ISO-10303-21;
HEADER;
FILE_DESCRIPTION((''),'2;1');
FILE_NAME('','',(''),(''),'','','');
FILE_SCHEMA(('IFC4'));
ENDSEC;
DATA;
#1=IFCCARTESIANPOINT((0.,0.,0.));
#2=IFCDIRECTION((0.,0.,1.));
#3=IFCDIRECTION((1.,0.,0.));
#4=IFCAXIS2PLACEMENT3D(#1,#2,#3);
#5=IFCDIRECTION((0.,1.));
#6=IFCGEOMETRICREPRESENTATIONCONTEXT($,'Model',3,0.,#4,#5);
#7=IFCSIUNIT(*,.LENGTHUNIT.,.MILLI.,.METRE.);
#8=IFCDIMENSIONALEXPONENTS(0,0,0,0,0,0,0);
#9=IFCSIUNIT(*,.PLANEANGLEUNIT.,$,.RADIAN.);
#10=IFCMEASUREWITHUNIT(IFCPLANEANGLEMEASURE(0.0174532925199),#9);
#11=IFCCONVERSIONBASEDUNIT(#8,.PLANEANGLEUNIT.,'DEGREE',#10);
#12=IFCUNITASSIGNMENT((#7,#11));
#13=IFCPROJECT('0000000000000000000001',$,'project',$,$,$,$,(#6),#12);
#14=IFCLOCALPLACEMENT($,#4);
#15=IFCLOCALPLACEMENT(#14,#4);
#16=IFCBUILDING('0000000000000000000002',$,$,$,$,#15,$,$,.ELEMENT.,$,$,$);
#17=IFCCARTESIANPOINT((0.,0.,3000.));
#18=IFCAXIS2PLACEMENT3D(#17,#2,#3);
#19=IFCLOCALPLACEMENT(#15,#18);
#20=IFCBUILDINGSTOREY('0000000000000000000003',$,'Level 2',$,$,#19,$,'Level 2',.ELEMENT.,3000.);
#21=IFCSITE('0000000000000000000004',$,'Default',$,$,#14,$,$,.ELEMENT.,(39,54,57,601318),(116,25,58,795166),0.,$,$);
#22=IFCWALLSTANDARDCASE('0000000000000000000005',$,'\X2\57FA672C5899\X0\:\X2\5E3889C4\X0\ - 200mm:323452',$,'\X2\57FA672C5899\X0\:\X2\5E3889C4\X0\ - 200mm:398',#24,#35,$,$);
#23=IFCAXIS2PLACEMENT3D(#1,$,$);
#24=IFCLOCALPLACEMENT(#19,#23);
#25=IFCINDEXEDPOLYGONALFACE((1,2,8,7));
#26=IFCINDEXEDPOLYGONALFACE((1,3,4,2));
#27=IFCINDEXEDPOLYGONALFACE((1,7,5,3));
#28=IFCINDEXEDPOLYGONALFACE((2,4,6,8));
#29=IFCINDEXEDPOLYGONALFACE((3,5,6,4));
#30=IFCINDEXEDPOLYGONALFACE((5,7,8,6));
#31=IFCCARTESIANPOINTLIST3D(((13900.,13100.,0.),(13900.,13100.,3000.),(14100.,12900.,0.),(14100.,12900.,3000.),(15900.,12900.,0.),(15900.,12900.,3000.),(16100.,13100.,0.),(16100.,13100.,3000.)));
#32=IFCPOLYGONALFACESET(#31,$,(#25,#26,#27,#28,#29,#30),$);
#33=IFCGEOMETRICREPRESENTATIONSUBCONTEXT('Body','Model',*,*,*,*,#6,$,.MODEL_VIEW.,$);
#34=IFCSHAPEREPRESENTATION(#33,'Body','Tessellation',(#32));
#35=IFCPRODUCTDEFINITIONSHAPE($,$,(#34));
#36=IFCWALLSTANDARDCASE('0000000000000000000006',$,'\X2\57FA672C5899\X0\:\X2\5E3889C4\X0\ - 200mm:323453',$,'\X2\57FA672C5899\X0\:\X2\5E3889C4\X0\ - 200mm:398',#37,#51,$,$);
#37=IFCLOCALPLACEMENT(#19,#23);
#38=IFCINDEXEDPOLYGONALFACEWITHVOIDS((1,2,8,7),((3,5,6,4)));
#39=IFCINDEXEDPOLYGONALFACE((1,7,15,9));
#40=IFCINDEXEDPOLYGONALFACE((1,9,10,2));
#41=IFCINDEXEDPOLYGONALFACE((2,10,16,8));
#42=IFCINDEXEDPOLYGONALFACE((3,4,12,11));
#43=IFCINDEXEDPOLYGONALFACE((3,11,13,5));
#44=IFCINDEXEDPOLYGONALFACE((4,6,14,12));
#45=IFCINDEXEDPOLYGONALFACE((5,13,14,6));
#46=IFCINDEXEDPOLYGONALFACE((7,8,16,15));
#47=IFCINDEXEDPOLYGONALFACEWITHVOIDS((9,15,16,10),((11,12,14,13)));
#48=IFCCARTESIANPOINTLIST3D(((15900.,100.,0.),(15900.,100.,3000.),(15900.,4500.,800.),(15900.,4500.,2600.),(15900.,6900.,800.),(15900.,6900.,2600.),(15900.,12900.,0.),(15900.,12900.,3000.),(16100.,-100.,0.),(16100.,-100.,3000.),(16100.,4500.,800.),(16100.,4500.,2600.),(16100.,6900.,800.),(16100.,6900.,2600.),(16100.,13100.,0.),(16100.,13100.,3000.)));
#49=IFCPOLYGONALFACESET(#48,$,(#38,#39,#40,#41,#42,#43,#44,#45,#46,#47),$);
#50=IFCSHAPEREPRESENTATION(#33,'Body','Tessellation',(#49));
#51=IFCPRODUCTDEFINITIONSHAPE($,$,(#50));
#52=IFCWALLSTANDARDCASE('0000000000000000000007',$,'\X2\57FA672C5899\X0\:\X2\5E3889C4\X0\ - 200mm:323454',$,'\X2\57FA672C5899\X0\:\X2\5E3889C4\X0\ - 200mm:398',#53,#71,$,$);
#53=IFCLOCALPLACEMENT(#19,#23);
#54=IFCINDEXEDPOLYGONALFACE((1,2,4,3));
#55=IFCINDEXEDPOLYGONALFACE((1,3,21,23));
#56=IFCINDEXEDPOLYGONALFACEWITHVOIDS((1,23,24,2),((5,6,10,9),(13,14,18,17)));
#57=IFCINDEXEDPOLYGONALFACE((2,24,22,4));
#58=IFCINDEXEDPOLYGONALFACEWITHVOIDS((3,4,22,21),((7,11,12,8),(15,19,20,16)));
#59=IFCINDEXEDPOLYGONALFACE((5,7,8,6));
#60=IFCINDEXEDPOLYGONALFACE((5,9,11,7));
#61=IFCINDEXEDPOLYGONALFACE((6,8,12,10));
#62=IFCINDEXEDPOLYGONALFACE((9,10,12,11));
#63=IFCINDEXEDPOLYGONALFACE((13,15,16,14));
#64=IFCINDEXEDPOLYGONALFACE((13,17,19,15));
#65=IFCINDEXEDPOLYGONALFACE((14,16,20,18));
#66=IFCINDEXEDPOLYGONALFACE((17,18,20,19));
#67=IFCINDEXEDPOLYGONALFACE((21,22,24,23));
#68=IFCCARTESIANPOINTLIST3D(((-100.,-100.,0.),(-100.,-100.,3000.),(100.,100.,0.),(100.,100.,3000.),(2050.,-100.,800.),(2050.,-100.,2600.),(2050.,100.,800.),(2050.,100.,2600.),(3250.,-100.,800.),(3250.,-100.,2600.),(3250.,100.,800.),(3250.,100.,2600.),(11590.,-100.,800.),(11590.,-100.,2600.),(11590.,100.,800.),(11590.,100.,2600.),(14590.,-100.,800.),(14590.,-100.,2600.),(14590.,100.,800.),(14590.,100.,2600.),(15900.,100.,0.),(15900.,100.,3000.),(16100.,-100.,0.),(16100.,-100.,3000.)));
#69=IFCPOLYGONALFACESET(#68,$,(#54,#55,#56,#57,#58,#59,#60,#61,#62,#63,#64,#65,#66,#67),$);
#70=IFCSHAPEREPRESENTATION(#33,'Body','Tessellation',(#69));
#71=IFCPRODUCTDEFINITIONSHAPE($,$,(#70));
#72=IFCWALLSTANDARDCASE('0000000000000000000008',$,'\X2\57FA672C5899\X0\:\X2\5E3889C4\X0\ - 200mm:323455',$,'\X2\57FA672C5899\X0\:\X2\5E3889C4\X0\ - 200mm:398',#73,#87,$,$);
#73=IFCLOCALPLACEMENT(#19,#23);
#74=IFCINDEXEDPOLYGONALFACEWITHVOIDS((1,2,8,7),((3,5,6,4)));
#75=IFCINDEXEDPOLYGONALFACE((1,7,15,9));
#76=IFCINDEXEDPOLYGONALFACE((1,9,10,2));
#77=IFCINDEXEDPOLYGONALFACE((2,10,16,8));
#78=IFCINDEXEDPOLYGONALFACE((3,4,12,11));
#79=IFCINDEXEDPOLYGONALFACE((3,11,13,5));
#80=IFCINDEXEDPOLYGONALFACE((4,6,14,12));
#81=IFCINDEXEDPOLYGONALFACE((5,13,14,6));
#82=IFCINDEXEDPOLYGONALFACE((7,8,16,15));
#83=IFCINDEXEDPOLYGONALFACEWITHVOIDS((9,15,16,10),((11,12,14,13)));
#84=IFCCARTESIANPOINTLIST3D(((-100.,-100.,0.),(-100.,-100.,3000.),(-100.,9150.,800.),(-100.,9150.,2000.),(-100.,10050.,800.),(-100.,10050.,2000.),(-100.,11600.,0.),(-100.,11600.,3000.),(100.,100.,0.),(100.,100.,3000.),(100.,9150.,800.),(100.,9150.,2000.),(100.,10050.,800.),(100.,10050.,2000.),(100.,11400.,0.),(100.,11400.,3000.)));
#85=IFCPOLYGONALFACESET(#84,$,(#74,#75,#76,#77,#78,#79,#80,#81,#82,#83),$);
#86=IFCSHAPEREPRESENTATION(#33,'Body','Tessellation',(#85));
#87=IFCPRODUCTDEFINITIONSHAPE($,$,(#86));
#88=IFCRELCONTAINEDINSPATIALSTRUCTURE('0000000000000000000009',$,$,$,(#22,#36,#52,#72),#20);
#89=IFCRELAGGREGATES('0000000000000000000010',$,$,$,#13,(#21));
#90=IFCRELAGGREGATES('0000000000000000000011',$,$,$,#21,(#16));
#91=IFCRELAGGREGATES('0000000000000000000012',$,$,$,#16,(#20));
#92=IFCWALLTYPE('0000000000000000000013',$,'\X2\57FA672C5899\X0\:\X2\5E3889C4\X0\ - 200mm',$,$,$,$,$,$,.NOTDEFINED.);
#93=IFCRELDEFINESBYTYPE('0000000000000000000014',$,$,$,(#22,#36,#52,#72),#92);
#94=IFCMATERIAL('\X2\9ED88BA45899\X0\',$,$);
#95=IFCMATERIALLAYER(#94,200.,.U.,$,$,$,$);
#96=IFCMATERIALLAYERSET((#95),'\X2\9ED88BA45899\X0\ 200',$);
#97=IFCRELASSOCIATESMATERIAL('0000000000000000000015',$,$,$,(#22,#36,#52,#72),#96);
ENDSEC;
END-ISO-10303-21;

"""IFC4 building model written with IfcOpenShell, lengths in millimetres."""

from ifc_helpers import new_model, entity, si_unit, converted_unit, direction, frame, origin_with_axes, place, context, subcontext, project, spatial, polyline, outline, extrude, material, layer, layer_set, layer_usage, type_object, element, save


model = new_model("IFC4")

# Units and contexts
model_context = context("Model", 3, precision=0.0, world=origin_with_axes(), true_north=direction((0.0, 1.0)))
body_context = subcontext(model_context, "Body", "Model", "MODEL_VIEW")
ifc_project = project(units=[si_unit("LENGTHUNIT", "METRE", prefix="MILLI"), converted_unit("PLANEANGLEUNIT", "DEGREE", entity("IfcPlaneAngleMeasure", 0.0174532925199), si_unit("PLANEANGLEUNIT", "RADIAN"), dimensions=[0, 0, 0, 0, 0, 0, 0])], contexts=[model_context])

# Site, building, storey
site_placement = place(None, origin_with_axes())
site = spatial("IfcSite", under=ifc_project, at=site_placement, Name="Default", CompositionType="ELEMENT", RefLatitude=(39, 54, 57, 601318), RefLongitude=(116, 25, 58, 795166), RefElevation=0.0)
building_placement = place(site_placement, origin_with_axes())
building = spatial("IfcBuilding", under=site, at=building_placement, CompositionType="ELEMENT")
storey_placement = place(building_placement, frame((0.0, 0.0, 3000.0), z_axis=(0.0, 0.0, 1.0), x_axis=(1.0, 0.0, 0.0)))
storey = spatial("IfcBuildingStorey", under=building, at=storey_placement, Name="Level 2", LongName="Level 2", CompositionType="ELEMENT", Elevation=3000.0)

# Shared definitions
ifc_material_1 = material(Name="默认墙")
ifc_layer_1 = layer(ifc_material_1, 200.0, ventilated="UNKNOWN")
ifc_layer_set_1 = layer_set([ifc_layer_1], Name="默认墙 200")
wall_type = type_object("IfcWallType", Name="基本墙:常规 - 200mm", PredefinedType="NOTDEFINED")

# Wall
ifc_layer_usage_1 = layer_usage(ifc_layer_set_1, "AXIS2", "POSITIVE", -100.0)
wall_1_placement = place(storey_placement, frame((14000.0, 13000.0, 0.0), z_axis=(0.0, 0.0, 1.0), x_axis=(1.0, 0.0, 0.0)))
element("IfcWallStandardCase", 1, at=wall_1_placement, inside=storey, type_object=wall_type, material=ifc_layer_usage_1, Name="基本墙:常规 - 200mm:323452", ObjectType="基本墙:常规 - 200mm:398", context=body_context, shape_type="SweptSolid", body=[
    extrude(outline(polyline([(100.0, -100.0), (1900.0, -100.0), (2100.0, 100.0), (-100.0, 100.0), (100.0, -100.0)])), origin_with_axes(), (0.0, 0.0, 1.0), 3000.0),
])

# Wall, opening
ifc_layer_usage_2 = layer_usage(ifc_layer_set_1, "AXIS2", "POSITIVE", -100.0)
wall_2_placement = place(storey_placement, frame((16000.0, 13000.0, 0.0), z_axis=(0.0, 0.0, 1.0), x_axis=(0.0, -1.0, 0.0)))
wall_2 = element("IfcWallStandardCase", 2, at=wall_2_placement, inside=storey, type_object=wall_type, material=ifc_layer_usage_2, Name="基本墙:常规 - 200mm:323453", ObjectType="基本墙:常规 - 200mm:398", context=body_context, shape_type="SweptSolid", body=[
    extrude(outline(polyline([(100.0, -100.0), (12900.0, -100.0), (13100.0, 100.0), (-100.0, 100.0), (100.0, -100.0)])), origin_with_axes(), (0.0, 0.0, 1.0), 3000.0),
])
opening_1_placement = place(wall_2_placement, frame((7300.0, 0.0, 800.0), z_axis=(0.0, 0.0, 1.0), x_axis=(1.0, 0.0, 0.0)))
element("IfcOpeningElement", 3, at=opening_1_placement, cuts=wall_2, context=body_context, shape_type="SweptSolid", body=[
    extrude(outline(polyline([(-1200.0, 0.0), (-1200.0, -1800.0), (1200.0, -1800.0), (1200.0, 0.0), (-1200.0, 0.0)])), frame((0.0, -100.0, 0.0), z_axis=(0.0, 1.0, 0.0), x_axis=(1.0, 0.0, 0.0)), (0.0, 0.0, 1.0), 200.0),
])

# Wall, openings
ifc_layer_usage_3 = layer_usage(ifc_layer_set_1, "AXIS2", "POSITIVE", -100.0)
wall_3_placement = place(storey_placement, frame((16000.0, 0.0, 0.0), z_axis=(0.0, 0.0, 1.0), x_axis=(-1.0, 0.0, 0.0)))
wall_3 = element("IfcWallStandardCase", 4, at=wall_3_placement, inside=storey, type_object=wall_type, material=ifc_layer_usage_3, Name="基本墙:常规 - 200mm:323454", ObjectType="基本墙:常规 - 200mm:398", context=body_context, shape_type="SweptSolid", body=[
    extrude(outline(polyline([(100.0, -100.0), (15900.0, -100.0), (16100.0, 100.0), (-100.0, 100.0), (100.0, -100.0)])), origin_with_axes(), (0.0, 0.0, 1.0), 3000.0),
])
opening_2_placement = place(wall_3_placement, frame((13350.0, 0.0, 800.0), z_axis=(0.0, 0.0, 1.0), x_axis=(1.0, 0.0, 0.0)))
element("IfcOpeningElement", 5, at=opening_2_placement, cuts=wall_3, context=body_context, shape_type="SweptSolid", body=[
    extrude(outline(polyline([(-600.0, 0.0), (-600.0, -1800.0), (600.0, -1800.0), (600.0, 0.0), (-600.0, 0.0)])), frame((0.0, -100.0, 0.0), z_axis=(0.0, 1.0, 0.0), x_axis=(1.0, 0.0, 0.0)), (0.0, 0.0, 1.0), 200.0),
])
opening_3_placement = place(wall_3_placement, frame((2910.0, 0.0, 800.0), z_axis=(0.0, 0.0, 1.0), x_axis=(1.0, 0.0, 0.0)))
element("IfcOpeningElement", 6, at=opening_3_placement, cuts=wall_3, context=body_context, shape_type="SweptSolid", body=[
    extrude(outline(polyline([(-1500.0, 0.0), (-1500.0, -1800.0), (1500.0, -1800.0), (1500.0, 0.0), (-1500.0, 0.0)])), frame((0.0, -100.0, 0.0), z_axis=(0.0, 1.0, 0.0), x_axis=(1.0, 0.0, 0.0)), (0.0, 0.0, 1.0), 200.0),
])

# Wall, opening
ifc_layer_usage_4 = layer_usage(ifc_layer_set_1, "AXIS2", "POSITIVE", -100.0)
wall_4_placement = place(storey_placement, frame((0.0, 0.0, 0.0), z_axis=(0.0, 0.0, 1.0), x_axis=(0.0, 1.0, 0.0)))
wall_4 = element("IfcWallStandardCase", 7, at=wall_4_placement, inside=storey, type_object=wall_type, material=ifc_layer_usage_4, Name="基本墙:常规 - 200mm:323455", ObjectType="基本墙:常规 - 200mm:398", context=body_context, shape_type="SweptSolid", body=[
    extrude(outline(polyline([(100.0, -100.0), (11400.0, -100.0), (11600.0, 100.0), (-100.0, 100.0), (100.0, -100.0)])), origin_with_axes(), (0.0, 0.0, 1.0), 3000.0),
])
opening_4_placement = place(wall_4_placement, frame((9600.0, 0.0, 800.0), z_axis=(0.0, 0.0, 1.0), x_axis=(1.0, 0.0, 0.0)))
element("IfcOpeningElement", 8, at=opening_4_placement, cuts=wall_4, context=body_context, shape_type="SweptSolid", body=[
    extrude(outline(polyline([(450.0, -1200.0), (450.0, 0.0), (-450.0, 0.0), (-450.0, -1200.0), (450.0, -1200.0)])), frame((0.0, 100.0, 0.0), z_axis=(0.0, -1.0, 0.0), x_axis=(-1.0, 0.0, 0.0)), (0.0, 0.0, 1.0), 200.0),
])

save(model, "model.ifc")
